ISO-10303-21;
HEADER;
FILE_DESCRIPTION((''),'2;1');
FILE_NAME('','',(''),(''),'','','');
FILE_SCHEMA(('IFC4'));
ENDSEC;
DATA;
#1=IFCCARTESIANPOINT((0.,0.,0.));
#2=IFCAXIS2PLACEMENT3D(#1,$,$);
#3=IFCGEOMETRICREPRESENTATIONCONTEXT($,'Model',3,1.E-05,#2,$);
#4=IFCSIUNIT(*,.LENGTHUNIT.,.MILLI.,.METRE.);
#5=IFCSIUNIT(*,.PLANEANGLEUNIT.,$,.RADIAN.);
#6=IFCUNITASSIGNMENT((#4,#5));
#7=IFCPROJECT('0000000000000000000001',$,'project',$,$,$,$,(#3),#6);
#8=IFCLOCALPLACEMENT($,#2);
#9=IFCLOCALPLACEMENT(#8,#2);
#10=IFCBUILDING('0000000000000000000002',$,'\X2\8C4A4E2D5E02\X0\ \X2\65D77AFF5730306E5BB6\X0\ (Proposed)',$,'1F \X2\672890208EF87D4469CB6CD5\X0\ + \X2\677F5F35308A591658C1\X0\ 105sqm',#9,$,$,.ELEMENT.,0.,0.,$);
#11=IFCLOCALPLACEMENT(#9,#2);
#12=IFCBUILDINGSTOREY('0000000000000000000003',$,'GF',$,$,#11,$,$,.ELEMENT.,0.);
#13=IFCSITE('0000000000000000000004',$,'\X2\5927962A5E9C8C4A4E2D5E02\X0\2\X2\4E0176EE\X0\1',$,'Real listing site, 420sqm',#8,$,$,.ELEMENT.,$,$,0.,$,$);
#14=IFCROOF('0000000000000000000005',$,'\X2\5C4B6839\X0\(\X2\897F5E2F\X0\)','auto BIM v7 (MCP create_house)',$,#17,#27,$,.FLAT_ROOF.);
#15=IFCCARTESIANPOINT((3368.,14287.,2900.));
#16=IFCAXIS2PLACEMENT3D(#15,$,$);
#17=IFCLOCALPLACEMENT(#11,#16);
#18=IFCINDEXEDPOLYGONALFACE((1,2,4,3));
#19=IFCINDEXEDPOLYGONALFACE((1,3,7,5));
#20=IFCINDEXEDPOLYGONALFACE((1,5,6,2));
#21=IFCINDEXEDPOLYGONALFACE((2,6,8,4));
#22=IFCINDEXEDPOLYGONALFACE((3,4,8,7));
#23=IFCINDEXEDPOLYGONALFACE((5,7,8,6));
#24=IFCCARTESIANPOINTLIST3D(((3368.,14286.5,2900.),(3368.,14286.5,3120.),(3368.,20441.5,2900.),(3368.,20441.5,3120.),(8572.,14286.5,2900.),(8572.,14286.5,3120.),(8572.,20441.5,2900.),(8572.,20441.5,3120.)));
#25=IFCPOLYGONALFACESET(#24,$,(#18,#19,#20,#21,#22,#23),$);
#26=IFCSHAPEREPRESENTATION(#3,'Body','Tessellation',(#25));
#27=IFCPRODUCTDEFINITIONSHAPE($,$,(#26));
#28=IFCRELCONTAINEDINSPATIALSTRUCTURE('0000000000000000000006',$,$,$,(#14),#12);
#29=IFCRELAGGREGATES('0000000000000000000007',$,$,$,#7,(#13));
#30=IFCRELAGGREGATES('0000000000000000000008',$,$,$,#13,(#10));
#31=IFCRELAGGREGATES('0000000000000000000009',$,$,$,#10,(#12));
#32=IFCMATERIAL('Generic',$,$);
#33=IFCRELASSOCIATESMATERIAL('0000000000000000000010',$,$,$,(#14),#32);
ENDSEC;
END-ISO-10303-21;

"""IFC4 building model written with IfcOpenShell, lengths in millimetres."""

from ifc_helpers import new_model, si_unit, frame, frame_2d, origin, place, context, project, spatial, rectangle, extrude, material, element, save


model = new_model("IFC4")

# Units and contexts
model_context = context("Model", 3, precision=1e-05, world=origin())
ifc_project = project(units=[si_unit("LENGTHUNIT", "METRE", prefix="MILLI"), si_unit("PLANEANGLEUNIT", "RADIAN")], contexts=[model_context])

# Site, building, storey
site_placement = place(None, origin())
site = spatial("IfcSite", under=ifc_project, at=site_placement, Name="大阪府豊中市2丁目1", ObjectType="Real listing site, 420sqm", CompositionType="ELEMENT", RefElevation=0.0)
building_placement = place(site_placement, origin())
building = spatial("IfcBuilding", under=site, at=building_placement, Name="豊中市 旗竿地の家 (Proposed)", ObjectType="1F 木造軸組構法 + 板張り外壁 105sqm", CompositionType="ELEMENT", ElevationOfRefHeight=0.0, ElevationOfTerrain=0.0)
storey_placement = place(building_placement, origin())
storey = spatial("IfcBuildingStorey", under=building, at=storey_placement, Name="GF", CompositionType="ELEMENT", Elevation=0.0)

# Shared definitions
ifc_material = material(Name="Generic")

# Roof
roof_1_placement = place(storey_placement, frame((3368.0, 14287.0, 2900.0)))
element("IfcRoof", 1, at=roof_1_placement, inside=storey, material=ifc_material, Name="屋根(西帯)", Description="auto BIM v7 (MCP create_house)", PredefinedType="FLAT_ROOF", context=model_context, shape_type="SweptSolid", body=[
    extrude(rectangle(XDim=5204.0, YDim=6155.0, at=frame_2d((2602.0, 3077.0))), frame((3368.0, 14287.0, 2900.0)), (0.0, 0.0, 1.0), 220.0),
])

save(model, "model.ifc")
